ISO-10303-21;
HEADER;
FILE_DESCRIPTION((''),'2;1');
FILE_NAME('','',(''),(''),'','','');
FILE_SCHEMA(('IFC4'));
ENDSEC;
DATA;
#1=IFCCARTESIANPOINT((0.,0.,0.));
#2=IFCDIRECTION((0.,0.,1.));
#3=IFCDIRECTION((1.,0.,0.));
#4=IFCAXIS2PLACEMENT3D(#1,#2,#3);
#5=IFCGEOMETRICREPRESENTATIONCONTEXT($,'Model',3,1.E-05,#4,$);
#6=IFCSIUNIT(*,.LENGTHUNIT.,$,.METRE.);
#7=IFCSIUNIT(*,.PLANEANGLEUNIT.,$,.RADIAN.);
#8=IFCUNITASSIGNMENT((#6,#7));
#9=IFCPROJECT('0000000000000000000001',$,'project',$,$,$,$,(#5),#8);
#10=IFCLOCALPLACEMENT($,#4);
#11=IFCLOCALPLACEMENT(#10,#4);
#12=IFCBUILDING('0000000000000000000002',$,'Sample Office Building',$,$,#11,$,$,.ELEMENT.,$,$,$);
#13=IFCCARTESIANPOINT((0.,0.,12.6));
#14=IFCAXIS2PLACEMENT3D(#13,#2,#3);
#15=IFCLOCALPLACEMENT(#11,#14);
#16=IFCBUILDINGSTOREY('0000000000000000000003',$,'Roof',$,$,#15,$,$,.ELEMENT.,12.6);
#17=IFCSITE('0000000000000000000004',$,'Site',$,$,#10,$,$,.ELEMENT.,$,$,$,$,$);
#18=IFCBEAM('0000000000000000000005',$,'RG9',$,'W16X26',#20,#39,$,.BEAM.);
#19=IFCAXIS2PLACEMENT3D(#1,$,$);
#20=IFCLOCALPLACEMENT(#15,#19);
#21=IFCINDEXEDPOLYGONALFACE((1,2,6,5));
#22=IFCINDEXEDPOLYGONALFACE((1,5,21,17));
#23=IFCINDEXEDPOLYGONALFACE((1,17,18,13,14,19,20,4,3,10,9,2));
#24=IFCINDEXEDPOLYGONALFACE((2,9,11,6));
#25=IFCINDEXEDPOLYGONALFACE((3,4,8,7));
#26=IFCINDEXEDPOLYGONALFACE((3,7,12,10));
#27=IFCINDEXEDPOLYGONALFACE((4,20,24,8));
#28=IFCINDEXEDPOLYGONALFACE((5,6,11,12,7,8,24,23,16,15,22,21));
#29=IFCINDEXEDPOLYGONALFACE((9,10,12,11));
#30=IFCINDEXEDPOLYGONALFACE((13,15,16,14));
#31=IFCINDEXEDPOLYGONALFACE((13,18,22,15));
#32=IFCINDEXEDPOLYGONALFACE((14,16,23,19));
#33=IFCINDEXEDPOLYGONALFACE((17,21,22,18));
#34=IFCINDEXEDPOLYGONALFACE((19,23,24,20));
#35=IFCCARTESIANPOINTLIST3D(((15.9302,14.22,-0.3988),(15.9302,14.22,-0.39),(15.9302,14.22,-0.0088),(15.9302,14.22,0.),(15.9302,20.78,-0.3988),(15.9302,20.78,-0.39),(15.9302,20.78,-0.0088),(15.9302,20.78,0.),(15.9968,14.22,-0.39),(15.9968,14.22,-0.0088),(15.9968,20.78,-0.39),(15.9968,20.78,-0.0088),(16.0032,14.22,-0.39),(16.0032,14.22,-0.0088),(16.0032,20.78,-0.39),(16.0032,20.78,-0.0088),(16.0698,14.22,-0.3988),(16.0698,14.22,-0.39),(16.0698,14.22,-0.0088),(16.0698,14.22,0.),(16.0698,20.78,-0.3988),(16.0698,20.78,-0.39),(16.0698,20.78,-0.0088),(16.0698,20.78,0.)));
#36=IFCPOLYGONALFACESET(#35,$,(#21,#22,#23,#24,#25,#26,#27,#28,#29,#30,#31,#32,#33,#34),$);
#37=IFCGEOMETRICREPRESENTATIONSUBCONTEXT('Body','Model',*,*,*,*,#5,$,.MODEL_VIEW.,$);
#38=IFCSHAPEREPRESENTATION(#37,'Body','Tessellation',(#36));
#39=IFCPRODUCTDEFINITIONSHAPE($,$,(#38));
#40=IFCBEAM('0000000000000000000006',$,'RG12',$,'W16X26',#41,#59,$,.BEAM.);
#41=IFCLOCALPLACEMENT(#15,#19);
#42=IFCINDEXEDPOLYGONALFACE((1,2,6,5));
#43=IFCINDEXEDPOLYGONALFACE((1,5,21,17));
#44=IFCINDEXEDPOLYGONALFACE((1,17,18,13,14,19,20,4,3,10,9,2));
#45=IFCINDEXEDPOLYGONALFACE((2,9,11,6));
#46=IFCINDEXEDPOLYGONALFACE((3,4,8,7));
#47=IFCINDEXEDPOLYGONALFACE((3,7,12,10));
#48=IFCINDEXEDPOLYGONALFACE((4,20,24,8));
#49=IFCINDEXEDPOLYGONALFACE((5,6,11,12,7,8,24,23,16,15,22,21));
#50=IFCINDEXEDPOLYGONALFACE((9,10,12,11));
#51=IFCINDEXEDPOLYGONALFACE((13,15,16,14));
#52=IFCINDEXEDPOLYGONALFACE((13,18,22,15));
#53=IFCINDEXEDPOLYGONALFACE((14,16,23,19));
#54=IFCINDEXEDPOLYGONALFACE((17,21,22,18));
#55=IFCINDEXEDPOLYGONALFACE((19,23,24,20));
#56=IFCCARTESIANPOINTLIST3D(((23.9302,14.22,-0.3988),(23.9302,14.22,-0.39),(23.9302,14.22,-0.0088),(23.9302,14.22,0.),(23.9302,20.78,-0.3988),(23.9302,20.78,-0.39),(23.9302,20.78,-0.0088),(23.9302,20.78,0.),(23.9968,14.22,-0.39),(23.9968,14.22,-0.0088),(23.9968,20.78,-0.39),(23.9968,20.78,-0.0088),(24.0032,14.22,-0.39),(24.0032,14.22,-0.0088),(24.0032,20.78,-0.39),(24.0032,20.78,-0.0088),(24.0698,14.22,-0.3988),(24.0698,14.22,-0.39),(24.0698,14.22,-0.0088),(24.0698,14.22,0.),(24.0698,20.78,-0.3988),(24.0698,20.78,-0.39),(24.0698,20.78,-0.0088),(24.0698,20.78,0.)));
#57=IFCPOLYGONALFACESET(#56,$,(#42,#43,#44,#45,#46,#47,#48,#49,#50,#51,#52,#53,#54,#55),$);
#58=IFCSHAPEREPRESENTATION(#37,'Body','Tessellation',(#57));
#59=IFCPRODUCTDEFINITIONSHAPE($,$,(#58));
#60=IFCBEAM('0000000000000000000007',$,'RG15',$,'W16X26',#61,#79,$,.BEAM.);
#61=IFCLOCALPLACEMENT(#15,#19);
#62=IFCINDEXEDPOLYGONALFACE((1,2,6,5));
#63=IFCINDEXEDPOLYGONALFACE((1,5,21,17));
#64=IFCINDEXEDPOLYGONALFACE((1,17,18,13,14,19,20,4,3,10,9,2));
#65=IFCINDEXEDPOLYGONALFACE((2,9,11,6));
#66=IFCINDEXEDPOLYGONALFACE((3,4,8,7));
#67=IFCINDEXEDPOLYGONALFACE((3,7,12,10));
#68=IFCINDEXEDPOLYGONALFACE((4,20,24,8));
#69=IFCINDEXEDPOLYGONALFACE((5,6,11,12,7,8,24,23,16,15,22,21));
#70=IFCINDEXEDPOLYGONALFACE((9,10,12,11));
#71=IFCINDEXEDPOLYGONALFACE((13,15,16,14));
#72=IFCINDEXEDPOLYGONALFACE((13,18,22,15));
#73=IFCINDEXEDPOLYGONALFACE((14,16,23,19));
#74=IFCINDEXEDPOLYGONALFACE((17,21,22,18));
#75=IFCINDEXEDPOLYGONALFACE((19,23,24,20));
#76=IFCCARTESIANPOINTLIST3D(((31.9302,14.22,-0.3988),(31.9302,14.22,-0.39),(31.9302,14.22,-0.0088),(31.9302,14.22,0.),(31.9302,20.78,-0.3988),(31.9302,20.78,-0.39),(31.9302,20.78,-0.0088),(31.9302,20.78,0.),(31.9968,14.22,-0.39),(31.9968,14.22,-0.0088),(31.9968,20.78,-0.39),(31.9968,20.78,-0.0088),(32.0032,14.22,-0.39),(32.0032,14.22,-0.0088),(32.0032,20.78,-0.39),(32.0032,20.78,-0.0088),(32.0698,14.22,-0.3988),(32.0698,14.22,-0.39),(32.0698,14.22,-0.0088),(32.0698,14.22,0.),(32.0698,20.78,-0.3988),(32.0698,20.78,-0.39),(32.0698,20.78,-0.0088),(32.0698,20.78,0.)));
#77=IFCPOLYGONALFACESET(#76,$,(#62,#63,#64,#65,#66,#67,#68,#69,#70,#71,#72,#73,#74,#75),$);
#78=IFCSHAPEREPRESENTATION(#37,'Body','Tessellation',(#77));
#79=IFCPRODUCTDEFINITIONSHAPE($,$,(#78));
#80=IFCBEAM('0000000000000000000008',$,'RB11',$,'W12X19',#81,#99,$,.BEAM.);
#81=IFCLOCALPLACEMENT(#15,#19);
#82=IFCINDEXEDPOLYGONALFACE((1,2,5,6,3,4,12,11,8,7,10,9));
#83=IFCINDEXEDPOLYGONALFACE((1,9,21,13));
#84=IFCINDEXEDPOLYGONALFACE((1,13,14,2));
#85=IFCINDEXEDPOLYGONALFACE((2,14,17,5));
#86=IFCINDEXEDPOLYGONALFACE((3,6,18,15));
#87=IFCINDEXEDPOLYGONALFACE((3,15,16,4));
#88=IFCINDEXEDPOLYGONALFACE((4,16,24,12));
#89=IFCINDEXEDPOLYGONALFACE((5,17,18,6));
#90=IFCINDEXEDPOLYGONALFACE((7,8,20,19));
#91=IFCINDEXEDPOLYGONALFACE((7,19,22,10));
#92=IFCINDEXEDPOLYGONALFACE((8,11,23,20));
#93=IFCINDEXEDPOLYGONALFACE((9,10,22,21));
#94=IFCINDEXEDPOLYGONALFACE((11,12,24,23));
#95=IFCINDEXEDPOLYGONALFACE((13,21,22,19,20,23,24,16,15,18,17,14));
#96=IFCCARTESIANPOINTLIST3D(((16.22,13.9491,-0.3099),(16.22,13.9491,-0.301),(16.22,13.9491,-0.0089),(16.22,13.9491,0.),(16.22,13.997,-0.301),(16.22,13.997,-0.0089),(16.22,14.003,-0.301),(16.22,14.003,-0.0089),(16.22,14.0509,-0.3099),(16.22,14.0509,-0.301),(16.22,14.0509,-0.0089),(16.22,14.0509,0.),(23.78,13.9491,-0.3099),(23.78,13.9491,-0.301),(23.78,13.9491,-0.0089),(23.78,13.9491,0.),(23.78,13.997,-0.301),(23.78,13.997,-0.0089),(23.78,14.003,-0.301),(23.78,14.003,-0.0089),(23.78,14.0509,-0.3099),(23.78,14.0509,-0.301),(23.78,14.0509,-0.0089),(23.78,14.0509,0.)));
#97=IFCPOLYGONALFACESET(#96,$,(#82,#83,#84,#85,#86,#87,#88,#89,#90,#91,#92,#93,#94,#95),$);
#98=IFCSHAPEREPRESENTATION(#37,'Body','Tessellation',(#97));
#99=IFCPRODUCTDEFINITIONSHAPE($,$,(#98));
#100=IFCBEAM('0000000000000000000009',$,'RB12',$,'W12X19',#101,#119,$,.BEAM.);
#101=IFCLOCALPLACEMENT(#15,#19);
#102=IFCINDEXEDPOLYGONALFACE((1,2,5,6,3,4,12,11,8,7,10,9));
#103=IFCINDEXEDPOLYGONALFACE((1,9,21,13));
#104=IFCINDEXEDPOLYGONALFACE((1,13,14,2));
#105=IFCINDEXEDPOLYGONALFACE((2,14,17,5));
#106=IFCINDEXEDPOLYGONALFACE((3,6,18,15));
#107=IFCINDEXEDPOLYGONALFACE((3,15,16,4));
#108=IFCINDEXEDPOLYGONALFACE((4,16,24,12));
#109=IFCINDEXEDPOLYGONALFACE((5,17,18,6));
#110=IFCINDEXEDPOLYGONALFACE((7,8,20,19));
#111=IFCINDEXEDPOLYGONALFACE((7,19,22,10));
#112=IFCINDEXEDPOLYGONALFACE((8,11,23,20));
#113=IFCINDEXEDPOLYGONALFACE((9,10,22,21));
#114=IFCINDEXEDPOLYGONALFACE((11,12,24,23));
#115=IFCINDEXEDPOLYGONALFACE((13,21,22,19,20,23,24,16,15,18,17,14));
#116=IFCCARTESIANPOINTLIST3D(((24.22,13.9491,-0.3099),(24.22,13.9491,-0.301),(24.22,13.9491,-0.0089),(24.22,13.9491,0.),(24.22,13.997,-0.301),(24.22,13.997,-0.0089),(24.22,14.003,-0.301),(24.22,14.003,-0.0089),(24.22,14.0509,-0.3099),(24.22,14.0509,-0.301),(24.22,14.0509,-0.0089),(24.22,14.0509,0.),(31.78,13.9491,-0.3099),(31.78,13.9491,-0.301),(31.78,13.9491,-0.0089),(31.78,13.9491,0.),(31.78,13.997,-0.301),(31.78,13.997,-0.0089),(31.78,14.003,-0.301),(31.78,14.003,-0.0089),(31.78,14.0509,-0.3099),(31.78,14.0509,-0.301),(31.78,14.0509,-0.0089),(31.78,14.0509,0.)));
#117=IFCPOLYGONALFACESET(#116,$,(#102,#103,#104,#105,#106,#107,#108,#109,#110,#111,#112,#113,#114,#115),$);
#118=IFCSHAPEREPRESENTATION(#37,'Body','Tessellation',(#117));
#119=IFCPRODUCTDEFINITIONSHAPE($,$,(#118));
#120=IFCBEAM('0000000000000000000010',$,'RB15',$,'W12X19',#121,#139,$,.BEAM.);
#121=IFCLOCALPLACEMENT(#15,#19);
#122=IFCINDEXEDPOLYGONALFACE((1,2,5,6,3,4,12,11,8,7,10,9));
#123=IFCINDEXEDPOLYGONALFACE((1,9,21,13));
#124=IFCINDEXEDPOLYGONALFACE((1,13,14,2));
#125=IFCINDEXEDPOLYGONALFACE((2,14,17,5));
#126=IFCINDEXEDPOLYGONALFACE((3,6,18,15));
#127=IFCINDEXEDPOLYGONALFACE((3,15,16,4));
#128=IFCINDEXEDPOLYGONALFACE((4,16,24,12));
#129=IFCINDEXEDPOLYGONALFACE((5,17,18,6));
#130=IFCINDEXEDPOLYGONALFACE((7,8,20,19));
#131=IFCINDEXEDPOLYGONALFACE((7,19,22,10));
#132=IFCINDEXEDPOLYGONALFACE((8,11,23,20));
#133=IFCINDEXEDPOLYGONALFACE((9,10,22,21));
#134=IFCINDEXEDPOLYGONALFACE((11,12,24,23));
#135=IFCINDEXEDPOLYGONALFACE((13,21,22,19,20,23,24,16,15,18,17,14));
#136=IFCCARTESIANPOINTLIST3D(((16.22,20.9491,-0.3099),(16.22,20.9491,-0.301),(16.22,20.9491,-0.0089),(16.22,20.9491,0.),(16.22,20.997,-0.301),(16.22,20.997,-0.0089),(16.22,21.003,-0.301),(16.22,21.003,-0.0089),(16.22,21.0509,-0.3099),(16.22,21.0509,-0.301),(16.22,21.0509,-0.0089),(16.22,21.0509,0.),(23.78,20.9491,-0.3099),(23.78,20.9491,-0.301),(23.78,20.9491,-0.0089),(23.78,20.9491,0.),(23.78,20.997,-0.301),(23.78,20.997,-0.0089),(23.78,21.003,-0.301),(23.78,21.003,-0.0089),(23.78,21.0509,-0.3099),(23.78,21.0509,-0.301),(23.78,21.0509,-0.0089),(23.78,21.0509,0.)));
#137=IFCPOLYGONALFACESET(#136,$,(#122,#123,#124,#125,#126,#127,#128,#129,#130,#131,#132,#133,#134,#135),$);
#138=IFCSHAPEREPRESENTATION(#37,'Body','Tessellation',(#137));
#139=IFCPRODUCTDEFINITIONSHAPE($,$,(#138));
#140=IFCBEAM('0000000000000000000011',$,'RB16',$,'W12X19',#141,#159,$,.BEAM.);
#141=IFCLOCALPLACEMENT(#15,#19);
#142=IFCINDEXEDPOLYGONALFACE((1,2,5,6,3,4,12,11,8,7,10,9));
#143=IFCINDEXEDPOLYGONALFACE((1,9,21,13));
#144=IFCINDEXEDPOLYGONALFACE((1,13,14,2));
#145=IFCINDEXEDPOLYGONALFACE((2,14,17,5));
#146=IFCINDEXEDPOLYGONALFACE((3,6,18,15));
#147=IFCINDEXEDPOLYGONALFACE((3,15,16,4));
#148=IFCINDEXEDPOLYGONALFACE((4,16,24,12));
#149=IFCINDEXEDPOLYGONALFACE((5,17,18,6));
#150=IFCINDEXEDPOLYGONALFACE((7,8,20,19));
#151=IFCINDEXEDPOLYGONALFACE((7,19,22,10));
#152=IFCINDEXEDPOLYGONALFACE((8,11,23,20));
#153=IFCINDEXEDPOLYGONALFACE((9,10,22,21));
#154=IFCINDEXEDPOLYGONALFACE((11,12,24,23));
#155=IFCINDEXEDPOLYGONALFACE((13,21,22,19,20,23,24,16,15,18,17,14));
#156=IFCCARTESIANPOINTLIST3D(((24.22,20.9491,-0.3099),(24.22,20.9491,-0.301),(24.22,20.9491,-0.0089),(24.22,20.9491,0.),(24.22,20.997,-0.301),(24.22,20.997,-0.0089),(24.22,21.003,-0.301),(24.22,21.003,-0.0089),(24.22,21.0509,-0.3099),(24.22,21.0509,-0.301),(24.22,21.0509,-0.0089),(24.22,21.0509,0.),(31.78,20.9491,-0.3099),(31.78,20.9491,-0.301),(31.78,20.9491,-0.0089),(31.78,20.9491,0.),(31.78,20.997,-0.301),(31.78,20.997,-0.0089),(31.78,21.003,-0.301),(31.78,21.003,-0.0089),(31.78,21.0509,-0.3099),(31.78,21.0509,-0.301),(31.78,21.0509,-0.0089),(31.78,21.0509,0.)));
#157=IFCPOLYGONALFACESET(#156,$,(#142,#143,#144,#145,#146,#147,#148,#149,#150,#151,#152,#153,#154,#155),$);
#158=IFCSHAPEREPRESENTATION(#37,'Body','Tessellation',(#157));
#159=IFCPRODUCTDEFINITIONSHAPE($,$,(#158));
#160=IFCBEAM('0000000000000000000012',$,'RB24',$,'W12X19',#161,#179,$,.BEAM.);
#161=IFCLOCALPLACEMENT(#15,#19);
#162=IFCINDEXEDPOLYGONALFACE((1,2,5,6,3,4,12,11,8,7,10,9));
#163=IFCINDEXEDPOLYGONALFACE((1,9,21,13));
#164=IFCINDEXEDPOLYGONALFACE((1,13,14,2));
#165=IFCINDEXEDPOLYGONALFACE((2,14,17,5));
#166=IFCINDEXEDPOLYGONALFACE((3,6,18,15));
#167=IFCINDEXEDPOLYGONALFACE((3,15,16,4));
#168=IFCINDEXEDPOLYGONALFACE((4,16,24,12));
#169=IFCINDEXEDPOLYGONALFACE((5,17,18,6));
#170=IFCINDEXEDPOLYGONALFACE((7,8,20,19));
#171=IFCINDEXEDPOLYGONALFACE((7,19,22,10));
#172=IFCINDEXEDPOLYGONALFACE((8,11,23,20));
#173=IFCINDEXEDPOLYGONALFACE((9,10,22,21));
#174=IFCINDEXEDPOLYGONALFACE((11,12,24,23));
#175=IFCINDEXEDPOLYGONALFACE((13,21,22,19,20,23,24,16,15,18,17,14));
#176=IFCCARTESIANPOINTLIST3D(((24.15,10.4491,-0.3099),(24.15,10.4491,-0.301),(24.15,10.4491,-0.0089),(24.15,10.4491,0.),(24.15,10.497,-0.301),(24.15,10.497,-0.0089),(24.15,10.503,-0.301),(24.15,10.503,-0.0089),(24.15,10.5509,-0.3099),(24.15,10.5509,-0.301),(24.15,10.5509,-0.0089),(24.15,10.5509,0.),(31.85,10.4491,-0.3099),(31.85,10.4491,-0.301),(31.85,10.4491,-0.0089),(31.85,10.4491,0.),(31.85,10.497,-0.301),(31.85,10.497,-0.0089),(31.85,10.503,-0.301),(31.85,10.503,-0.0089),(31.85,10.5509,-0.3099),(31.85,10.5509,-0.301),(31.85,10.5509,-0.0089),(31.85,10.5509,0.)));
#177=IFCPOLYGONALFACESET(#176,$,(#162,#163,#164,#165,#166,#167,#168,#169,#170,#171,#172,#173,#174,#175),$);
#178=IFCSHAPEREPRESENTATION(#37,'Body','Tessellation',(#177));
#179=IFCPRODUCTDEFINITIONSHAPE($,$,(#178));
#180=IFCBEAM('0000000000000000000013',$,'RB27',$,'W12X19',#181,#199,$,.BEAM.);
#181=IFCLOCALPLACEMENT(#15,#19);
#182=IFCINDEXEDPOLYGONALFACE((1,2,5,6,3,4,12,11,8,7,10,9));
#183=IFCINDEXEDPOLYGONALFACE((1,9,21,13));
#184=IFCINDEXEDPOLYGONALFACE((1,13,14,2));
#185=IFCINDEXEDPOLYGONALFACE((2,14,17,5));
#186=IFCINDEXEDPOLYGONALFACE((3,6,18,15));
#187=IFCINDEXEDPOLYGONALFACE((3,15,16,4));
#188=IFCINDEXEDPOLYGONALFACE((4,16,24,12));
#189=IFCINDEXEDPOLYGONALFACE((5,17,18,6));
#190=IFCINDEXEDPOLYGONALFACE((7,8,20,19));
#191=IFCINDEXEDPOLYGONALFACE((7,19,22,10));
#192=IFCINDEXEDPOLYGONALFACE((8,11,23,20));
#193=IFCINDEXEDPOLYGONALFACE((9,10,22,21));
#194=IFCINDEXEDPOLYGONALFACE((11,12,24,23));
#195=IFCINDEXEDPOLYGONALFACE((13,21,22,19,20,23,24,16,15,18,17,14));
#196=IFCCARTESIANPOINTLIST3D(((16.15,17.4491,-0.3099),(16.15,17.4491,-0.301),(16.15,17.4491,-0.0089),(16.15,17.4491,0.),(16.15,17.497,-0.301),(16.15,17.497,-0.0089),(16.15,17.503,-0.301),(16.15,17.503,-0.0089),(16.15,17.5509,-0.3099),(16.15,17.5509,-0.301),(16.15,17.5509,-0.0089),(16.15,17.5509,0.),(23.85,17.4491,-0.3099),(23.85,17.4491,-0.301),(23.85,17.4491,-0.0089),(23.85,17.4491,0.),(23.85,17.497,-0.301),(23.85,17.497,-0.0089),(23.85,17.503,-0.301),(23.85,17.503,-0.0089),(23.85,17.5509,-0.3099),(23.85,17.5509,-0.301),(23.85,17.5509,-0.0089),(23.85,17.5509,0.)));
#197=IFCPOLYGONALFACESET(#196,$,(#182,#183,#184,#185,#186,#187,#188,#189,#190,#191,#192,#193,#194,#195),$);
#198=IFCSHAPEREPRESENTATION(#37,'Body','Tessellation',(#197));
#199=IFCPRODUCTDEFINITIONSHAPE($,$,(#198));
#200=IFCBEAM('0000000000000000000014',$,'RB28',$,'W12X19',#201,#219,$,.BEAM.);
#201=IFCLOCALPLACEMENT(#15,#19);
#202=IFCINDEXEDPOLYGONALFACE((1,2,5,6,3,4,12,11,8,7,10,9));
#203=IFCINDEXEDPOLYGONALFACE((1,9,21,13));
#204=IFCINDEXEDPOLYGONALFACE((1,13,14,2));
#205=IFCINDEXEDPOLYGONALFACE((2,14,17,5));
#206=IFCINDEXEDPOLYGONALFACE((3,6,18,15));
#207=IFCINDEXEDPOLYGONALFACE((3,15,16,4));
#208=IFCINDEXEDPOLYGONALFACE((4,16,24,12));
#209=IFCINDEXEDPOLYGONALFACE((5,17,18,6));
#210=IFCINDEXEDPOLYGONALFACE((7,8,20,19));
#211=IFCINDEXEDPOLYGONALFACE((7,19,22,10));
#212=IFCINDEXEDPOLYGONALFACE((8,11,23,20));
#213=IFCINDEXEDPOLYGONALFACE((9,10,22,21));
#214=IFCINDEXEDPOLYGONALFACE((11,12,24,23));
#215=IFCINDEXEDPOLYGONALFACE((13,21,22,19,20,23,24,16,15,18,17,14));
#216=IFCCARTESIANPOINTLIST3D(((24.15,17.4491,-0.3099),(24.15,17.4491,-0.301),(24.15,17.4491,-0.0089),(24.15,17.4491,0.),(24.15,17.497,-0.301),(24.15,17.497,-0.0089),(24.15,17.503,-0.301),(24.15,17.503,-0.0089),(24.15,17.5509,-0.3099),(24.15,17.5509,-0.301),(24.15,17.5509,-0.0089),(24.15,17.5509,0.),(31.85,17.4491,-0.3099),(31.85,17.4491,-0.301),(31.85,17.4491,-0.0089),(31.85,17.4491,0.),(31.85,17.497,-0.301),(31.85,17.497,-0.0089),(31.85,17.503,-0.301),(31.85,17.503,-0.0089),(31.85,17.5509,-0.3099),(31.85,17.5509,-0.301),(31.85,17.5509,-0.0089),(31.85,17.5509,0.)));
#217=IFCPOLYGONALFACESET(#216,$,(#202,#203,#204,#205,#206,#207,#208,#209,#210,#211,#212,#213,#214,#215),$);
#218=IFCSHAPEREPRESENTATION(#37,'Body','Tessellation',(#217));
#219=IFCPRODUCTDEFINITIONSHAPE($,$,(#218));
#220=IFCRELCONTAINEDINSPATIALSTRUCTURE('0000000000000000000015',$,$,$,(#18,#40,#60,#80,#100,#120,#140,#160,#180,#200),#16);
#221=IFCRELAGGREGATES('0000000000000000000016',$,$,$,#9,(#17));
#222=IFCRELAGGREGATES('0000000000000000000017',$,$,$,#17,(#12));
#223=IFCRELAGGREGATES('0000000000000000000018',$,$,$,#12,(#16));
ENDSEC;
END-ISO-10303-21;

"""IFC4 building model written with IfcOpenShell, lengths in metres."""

from ifc_helpers import new_model, si_unit, frame, origin_with_axes, place, context, subcontext, project, spatial, i_section, extrude, element, save


model = new_model("IFC4")

# Units and contexts
model_context = context("Model", 3, precision=1e-05, world=origin_with_axes())
body_context = subcontext(model_context, "Body", "Model", "MODEL_VIEW")
ifc_project = project(units=[si_unit("LENGTHUNIT", "METRE"), si_unit("PLANEANGLEUNIT", "RADIAN")], contexts=[model_context])

# Site, building, storey
site_placement = place(None, origin_with_axes())
site = spatial("IfcSite", under=ifc_project, at=site_placement, Name="Site", CompositionType="ELEMENT")
building_placement = place(site_placement, origin_with_axes())
building = spatial("IfcBuilding", under=site, at=building_placement, Name="Sample Office Building", CompositionType="ELEMENT")
storey_placement = place(building_placement, frame((0.0, 0.0, 12.6), z_axis=(0.0, 0.0, 1.0), x_axis=(1.0, 0.0, 0.0)))
storey = spatial("IfcBuildingStorey", under=building, at=storey_placement, Name="Roof", CompositionType="ELEMENT", Elevation=12.6)

# Beams
for number, where, z_axis, x_axis, name in (
    (1, (16.0, 14.22, 12.4006), (0.0, 1.0, 0.0), (-1.0, 0.0, 0.0), "RG9"),
    (2, (24.0, 14.22, 12.4006), (0.0, 1.0, 0.0), (-1.0, 0.0, 0.0), "RG12"),
    (3, (32.0, 14.22, 12.4006), (0.0, 1.0, 0.0), (-1.0, 0.0, 0.0), "RG15"),
):
    element("IfcBeam", number, at=place(None, frame(where, z_axis=z_axis, x_axis=x_axis)), inside=storey, Name=name, ObjectType="W16X26", PredefinedType="BEAM", context=body_context, shape_type="SweptSolid", body=[
        extrude(i_section(OverallWidth=0.1397, OverallDepth=0.3988, WebThickness=0.0063, FlangeThickness=0.0088), None, (0.0, 0.0, 1.0), 6.56),
    ])
for number, where, z_axis, x_axis, name in (
    (4, (16.22, 14.0, 12.4451), (1.0, 0.0, 0.0), (0.0, 1.0, 0.0), "RB11"),
    (5, (24.22, 14.0, 12.4451), (1.0, 0.0, 0.0), (0.0, 1.0, 0.0), "RB12"),
    (6, (16.22, 21.0, 12.4451), (1.0, 0.0, 0.0), (0.0, 1.0, 0.0), "RB15"),
    (7, (24.22, 21.0, 12.4451), (1.0, 0.0, 0.0), (0.0, 1.0, 0.0), "RB16"),
):
    element("IfcBeam", number, at=place(None, frame(where, z_axis=z_axis, x_axis=x_axis)), inside=storey, Name=name, ObjectType="W12X19", PredefinedType="BEAM", context=body_context, shape_type="SweptSolid", body=[
        extrude(i_section(OverallWidth=0.1019, OverallDepth=0.3099, WebThickness=0.006, FlangeThickness=0.0089), None, (0.0, 0.0, 1.0), 7.56),
    ])
for number, where, z_axis, x_axis, name in (
    (8, (24.15, 10.5, 12.4451), (1.0, 0.0, 0.0), (0.0, 1.0, 0.0), "RB24"),
    (9, (16.15, 17.5, 12.4451), (1.0, 0.0, 0.0), (0.0, 1.0, 0.0), "RB27"),
    (10, (24.15, 17.5, 12.4451), (1.0, 0.0, 0.0), (0.0, 1.0, 0.0), "RB28"),
):
    element("IfcBeam", number, at=place(None, frame(where, z_axis=z_axis, x_axis=x_axis)), inside=storey, Name=name, ObjectType="W12X19", PredefinedType="BEAM", context=body_context, shape_type="SweptSolid", body=[
        extrude(i_section(OverallWidth=0.1019, OverallDepth=0.3099, WebThickness=0.006, FlangeThickness=0.0089), None, (0.0, 0.0, 1.0), 7.7),
    ])

save(model, "model.ifc")
